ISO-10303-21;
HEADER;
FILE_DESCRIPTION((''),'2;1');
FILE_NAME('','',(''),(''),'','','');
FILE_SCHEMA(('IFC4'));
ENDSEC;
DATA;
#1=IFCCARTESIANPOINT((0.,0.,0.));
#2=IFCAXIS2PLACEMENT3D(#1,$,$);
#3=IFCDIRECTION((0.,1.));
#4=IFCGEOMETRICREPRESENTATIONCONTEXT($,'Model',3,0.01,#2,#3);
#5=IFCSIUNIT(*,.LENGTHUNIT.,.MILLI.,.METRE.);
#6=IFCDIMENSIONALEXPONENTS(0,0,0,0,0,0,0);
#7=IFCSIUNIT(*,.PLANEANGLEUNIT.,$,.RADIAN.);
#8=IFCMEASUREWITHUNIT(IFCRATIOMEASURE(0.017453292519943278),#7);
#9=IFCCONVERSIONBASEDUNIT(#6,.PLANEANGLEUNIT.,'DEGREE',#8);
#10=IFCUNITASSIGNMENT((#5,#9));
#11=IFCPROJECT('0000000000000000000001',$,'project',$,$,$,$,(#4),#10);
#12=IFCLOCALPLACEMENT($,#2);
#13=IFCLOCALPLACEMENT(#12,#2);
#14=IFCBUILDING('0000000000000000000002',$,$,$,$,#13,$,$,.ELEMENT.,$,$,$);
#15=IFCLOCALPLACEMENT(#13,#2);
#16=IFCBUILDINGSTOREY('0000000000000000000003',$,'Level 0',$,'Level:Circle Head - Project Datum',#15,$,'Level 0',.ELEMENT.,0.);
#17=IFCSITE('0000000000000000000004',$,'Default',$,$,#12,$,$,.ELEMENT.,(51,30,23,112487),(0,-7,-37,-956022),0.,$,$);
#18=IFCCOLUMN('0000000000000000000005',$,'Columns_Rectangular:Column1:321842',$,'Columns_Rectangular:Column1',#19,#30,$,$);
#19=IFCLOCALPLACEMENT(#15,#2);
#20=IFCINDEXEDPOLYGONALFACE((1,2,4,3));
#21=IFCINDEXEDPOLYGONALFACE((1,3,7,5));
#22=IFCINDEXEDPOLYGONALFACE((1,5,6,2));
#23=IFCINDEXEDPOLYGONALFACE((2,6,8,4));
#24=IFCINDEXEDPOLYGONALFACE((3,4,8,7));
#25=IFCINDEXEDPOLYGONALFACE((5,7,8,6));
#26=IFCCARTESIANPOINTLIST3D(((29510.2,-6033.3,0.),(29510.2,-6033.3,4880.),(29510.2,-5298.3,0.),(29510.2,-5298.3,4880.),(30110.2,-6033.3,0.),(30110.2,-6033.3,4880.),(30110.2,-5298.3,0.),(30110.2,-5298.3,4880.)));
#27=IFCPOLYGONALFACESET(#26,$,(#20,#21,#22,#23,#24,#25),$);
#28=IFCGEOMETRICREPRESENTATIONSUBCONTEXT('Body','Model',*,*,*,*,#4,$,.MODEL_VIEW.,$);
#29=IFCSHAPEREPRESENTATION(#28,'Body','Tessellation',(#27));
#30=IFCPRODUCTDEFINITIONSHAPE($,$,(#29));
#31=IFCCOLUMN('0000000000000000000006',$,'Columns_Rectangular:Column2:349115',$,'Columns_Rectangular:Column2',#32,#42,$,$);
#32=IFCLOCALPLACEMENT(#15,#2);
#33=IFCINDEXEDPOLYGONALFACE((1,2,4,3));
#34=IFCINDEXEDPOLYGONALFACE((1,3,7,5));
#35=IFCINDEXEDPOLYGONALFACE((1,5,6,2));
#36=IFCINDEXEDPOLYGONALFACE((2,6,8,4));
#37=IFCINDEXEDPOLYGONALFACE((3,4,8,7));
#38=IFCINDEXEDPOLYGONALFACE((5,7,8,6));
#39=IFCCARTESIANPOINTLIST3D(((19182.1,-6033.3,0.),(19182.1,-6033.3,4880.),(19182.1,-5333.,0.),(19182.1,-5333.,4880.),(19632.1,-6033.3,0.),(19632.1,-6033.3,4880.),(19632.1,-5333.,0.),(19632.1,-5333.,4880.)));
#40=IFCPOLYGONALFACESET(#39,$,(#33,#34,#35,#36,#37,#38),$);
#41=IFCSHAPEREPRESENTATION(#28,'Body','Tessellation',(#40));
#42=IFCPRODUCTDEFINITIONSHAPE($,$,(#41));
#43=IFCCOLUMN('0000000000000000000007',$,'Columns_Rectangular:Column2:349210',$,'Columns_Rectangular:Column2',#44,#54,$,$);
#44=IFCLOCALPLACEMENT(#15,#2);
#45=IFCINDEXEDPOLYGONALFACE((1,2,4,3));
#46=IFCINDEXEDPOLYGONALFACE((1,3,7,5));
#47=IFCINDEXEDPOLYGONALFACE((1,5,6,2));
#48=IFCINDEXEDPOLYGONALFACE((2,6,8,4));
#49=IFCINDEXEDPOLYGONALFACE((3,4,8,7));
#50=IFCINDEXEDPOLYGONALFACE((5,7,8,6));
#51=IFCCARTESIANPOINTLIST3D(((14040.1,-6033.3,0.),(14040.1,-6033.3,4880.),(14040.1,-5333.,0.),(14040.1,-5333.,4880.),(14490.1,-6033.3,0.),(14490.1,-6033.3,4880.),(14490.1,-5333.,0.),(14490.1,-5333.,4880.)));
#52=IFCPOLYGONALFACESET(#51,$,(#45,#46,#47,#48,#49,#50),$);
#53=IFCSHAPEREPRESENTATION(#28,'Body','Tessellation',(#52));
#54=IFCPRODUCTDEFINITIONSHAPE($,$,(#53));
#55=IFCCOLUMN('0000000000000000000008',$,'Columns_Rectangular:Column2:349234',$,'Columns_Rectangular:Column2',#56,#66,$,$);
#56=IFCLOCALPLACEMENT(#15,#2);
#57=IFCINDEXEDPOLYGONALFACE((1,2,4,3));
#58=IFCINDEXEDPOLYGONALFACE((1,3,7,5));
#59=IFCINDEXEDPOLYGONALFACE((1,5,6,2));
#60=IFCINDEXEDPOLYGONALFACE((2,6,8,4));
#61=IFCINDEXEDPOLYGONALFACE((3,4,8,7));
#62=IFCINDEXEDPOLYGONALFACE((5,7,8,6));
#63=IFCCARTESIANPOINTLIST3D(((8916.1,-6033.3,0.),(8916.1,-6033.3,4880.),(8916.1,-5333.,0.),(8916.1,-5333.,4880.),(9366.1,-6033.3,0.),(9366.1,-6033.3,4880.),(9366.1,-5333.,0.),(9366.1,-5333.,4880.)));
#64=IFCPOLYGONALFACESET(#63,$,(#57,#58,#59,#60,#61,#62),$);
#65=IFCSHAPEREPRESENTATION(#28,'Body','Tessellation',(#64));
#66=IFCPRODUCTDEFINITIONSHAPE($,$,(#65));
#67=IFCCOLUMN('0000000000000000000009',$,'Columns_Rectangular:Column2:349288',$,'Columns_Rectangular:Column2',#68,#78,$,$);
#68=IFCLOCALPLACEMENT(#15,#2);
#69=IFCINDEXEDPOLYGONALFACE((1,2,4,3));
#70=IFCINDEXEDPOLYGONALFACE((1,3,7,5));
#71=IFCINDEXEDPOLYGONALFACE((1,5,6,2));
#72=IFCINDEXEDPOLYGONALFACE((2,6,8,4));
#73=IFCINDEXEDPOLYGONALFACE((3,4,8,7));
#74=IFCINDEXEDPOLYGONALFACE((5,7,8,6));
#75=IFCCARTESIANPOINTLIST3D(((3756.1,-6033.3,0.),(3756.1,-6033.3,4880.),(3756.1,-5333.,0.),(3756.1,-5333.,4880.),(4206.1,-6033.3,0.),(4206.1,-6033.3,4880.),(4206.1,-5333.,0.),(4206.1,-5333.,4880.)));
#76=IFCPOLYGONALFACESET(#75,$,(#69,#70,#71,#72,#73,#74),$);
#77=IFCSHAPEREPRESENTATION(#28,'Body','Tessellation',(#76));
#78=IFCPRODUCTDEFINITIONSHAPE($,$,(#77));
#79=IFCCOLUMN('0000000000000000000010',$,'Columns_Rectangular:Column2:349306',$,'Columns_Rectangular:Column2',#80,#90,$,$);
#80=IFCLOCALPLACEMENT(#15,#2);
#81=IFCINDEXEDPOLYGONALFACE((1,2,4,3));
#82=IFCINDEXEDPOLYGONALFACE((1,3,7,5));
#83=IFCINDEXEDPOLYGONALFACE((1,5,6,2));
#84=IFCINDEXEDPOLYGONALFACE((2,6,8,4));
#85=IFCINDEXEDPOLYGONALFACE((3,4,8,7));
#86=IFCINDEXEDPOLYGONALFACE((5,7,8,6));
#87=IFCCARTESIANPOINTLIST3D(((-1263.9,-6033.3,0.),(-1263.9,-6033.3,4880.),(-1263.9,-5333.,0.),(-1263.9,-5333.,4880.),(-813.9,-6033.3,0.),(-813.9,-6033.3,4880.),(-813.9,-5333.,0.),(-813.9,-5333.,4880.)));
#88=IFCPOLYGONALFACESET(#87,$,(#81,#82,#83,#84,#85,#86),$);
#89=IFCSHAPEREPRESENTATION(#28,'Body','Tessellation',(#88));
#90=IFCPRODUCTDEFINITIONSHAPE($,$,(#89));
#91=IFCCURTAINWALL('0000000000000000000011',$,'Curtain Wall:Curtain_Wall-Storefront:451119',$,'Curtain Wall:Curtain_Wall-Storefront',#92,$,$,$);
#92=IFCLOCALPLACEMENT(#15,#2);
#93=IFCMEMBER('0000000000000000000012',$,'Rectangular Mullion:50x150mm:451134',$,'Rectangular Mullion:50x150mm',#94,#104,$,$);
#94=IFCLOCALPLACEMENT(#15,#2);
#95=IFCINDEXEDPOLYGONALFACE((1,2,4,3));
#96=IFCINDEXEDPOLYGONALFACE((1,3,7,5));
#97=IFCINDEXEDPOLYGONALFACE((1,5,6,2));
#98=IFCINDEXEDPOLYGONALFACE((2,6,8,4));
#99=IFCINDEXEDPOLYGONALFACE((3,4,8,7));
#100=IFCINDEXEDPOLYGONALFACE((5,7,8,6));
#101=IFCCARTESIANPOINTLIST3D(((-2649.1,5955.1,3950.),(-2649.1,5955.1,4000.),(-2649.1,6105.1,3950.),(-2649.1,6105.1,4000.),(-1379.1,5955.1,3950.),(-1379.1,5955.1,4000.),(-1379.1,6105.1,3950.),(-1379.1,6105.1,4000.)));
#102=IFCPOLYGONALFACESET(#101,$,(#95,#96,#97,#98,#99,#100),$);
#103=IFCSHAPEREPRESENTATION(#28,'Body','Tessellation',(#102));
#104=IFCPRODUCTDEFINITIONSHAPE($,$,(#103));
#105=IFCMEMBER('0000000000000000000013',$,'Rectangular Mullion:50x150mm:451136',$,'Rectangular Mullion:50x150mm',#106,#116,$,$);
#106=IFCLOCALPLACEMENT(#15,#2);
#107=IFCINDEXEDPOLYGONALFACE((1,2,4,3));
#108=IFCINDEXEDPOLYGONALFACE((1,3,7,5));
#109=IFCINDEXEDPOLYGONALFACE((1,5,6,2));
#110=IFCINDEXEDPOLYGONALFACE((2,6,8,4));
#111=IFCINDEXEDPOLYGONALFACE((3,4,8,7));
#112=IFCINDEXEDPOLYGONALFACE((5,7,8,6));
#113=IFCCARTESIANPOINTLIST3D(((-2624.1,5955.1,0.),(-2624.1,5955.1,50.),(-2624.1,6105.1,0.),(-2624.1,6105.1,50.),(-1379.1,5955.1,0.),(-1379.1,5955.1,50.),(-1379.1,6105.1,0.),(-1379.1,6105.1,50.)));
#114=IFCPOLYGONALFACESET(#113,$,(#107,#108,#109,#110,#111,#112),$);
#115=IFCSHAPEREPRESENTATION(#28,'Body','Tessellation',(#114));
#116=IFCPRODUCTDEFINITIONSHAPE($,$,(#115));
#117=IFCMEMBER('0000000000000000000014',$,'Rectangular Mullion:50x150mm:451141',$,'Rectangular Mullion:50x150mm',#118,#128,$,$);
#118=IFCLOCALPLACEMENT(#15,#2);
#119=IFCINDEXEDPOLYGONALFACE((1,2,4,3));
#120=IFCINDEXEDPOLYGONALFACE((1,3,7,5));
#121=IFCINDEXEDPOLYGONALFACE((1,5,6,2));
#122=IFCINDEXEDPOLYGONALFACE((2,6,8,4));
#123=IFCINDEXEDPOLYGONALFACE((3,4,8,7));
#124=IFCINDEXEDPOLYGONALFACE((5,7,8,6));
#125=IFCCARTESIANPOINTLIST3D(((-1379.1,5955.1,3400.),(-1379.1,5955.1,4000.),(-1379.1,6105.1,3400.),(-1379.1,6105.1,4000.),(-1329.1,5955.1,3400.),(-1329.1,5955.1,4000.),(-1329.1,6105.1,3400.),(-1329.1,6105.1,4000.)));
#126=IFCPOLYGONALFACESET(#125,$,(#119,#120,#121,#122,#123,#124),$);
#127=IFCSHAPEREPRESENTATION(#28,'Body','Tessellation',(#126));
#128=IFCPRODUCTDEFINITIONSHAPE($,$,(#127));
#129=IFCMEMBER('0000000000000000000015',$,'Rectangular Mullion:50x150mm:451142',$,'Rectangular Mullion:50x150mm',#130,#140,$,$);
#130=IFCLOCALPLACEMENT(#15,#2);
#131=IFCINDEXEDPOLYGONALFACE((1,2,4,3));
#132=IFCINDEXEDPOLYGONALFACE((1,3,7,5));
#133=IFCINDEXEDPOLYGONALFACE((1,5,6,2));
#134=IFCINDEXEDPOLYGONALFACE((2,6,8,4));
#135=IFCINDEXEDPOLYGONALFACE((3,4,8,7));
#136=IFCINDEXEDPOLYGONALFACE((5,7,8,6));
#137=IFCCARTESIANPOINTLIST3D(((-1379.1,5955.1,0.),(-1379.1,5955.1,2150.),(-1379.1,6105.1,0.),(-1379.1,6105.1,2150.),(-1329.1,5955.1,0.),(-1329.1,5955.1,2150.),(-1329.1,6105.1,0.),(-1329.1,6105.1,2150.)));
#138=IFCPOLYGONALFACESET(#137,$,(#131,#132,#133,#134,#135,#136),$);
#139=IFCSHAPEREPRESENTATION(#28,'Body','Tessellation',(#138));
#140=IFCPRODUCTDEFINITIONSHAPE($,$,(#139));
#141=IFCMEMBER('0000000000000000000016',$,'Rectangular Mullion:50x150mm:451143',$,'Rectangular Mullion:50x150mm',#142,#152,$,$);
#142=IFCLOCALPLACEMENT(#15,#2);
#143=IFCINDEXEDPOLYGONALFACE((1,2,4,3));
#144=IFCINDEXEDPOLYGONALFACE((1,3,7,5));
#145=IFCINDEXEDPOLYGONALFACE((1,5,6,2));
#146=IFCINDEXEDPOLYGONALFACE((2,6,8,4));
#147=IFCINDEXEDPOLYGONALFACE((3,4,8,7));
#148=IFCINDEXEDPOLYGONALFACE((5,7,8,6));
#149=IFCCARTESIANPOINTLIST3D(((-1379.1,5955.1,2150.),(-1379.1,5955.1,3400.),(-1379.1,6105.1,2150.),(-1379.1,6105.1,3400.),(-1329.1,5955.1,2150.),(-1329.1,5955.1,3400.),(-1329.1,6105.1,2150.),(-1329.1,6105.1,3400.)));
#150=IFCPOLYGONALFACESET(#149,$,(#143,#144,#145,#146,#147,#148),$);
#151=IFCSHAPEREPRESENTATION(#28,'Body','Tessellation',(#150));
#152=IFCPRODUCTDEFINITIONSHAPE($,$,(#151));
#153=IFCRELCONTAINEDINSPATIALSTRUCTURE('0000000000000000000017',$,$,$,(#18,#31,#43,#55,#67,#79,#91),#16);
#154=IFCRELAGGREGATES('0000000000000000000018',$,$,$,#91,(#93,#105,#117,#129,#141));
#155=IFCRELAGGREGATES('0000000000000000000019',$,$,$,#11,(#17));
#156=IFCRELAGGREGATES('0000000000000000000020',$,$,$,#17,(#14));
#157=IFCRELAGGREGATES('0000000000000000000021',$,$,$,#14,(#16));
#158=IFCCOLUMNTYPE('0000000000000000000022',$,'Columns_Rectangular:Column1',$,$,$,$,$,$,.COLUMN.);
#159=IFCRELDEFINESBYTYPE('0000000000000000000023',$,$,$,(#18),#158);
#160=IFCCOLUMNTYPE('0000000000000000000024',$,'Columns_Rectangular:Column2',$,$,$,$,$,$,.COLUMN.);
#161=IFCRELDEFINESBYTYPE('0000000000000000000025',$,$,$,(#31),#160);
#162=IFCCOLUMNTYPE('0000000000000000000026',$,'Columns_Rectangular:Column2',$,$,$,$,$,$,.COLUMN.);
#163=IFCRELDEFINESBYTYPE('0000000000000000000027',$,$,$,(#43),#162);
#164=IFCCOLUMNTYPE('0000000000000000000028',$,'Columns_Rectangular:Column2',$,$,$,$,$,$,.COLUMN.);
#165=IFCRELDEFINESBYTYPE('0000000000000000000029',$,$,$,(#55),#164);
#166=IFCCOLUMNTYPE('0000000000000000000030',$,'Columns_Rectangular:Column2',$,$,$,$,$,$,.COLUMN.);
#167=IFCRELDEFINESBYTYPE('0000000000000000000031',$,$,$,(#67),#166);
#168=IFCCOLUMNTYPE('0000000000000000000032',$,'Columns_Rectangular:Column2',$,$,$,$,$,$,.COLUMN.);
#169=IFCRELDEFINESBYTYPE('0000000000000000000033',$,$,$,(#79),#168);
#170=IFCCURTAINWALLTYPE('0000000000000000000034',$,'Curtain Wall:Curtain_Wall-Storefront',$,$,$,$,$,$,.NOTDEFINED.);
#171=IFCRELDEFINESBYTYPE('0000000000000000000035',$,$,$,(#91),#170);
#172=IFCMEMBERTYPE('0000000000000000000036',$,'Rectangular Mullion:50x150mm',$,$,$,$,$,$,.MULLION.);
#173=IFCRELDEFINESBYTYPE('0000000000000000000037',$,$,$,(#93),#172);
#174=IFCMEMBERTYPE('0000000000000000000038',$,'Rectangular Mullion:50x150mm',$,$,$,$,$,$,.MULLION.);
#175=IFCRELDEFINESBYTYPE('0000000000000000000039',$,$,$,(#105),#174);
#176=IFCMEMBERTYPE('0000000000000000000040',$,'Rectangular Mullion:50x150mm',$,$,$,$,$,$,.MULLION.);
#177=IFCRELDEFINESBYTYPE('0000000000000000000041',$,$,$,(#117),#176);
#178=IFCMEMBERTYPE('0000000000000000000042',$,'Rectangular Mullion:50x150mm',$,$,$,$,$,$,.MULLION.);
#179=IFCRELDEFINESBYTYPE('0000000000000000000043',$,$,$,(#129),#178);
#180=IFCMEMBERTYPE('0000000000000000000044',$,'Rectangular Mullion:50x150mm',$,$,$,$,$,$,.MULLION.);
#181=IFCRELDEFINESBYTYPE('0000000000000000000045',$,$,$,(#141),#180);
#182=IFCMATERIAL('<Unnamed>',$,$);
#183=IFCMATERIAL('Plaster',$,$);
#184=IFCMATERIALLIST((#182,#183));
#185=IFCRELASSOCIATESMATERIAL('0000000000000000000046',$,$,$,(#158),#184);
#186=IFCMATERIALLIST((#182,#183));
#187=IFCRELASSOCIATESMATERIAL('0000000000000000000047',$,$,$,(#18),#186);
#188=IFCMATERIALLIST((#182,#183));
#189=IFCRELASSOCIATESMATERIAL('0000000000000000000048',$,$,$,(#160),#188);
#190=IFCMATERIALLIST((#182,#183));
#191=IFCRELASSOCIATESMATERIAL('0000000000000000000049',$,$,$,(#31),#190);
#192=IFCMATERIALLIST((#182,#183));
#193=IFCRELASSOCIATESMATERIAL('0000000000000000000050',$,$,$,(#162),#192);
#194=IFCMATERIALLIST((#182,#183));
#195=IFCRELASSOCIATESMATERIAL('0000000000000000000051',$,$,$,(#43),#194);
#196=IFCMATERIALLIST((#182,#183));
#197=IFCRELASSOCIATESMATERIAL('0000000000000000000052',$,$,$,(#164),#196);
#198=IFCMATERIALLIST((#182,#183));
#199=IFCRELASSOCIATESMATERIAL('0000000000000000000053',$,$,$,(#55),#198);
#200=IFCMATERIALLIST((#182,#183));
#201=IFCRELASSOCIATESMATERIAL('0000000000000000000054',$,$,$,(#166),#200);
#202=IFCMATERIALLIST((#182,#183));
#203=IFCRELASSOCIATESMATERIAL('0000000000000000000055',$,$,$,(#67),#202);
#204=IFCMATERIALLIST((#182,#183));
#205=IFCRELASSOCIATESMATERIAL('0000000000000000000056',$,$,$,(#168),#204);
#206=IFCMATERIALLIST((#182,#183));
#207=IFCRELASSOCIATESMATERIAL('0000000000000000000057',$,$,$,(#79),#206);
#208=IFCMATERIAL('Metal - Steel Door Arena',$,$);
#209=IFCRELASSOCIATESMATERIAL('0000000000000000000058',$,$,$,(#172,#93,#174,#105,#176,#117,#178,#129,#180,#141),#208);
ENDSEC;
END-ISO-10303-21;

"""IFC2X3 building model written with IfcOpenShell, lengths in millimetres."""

from ifc_helpers import new_model, entity, si_unit, converted_unit, direction, frame, frame_2d, origin, origin_2d_with_axis, place, context, subcontext, project, spatial, rectangle, extrude, source, transform, mapped, material, material_list, type_object, type_shapes, element, aggregate, save


model = new_model("IFC2X3")

# Units and contexts
model_context = context("Model", 3, precision=0.01, world=origin(), true_north=direction((0.0, 1.0)))
body_context = subcontext(model_context, "Body", "Model", "MODEL_VIEW")
ifc_project = project(units=[si_unit("LENGTHUNIT", "METRE", prefix="MILLI"), converted_unit("PLANEANGLEUNIT", "DEGREE", entity("IfcRatioMeasure", 0.017453292519943278), si_unit("PLANEANGLEUNIT", "RADIAN"), dimensions=[0, 0, 0, 0, 0, 0, 0])], contexts=[model_context])

# Site, building, storey
site_placement = place(None, origin())
site = spatial("IfcSite", under=ifc_project, at=site_placement, Name="Default", CompositionType="ELEMENT", RefLatitude=(51, 30, 23, 112487), RefLongitude=(0, -7, -37, -956022), RefElevation=0.0)
building_placement = place(site_placement, origin())
building = spatial("IfcBuilding", under=site, at=building_placement, CompositionType="ELEMENT")
storey_placement = place(building_placement, origin())
storey = spatial("IfcBuildingStorey", under=building, at=storey_placement, Name="Level 0", ObjectType="Level:Circle Head - Project Datum", LongName="Level 0", CompositionType="ELEMENT", Elevation=0.0)

# Columns
ifc_material_1 = material(Name="<Unnamed>")
ifc_material_2 = material(Name="Plaster")
ifc_material_list_1 = material_list([ifc_material_1, ifc_material_2])
ifc_material_list_2 = material_list([ifc_material_1, ifc_material_2])
column_type_1 = type_object("IfcColumnType", Name="Columns_Rectangular:Column1", PredefinedType="COLUMN", material=ifc_material_list_2)
shared_shape_1 = source(origin(), body_context, "Body", "SweptSolid", [
    extrude(rectangle(XDim=735.0, YDim=600.0, at=frame_2d((0.0, 0.0), x_axis=(1.0, 0.0))), frame((29810.2, -5665.8, 0.0), z_axis=(0.0, 0.0, 1.0), x_axis=(0.0, -1.0, 0.0)), (0.0, 0.0, 1.0), 4880.0),
])
type_shapes(column_type_1, [shared_shape_1])
column_1_placement = place(storey_placement, origin())
element("IfcColumn", 1, at=column_1_placement, inside=storey, type_object=column_type_1, material=ifc_material_list_1, Name="Columns_Rectangular:Column1:321842", ObjectType="Columns_Rectangular:Column1", context=body_context, shape_type="MappedRepresentation", body=[
    mapped(shared_shape_1, transform((0.0, 0.0, 0.0), scale=1.0)),
])
ifc_material_list_3 = material_list([ifc_material_1, ifc_material_2])
ifc_material_list_4 = material_list([ifc_material_1, ifc_material_2])
column_type_2 = type_object("IfcColumnType", Name="Columns_Rectangular:Column2", PredefinedType="COLUMN", material=ifc_material_list_4)
shared_shape_2 = source(origin(), body_context, "Body", "SweptSolid", [
    extrude(rectangle(XDim=700.3, YDim=450.0, at=frame_2d((0.0, 0.0), x_axis=(1.0, 0.0))), frame((19407.1, -5683.1, 0.0), z_axis=(0.0, 0.0, 1.0), x_axis=(0.0, -1.0, 0.0)), (0.0, 0.0, 1.0), 4880.0),
])
type_shapes(column_type_2, [shared_shape_2])
column_2_placement = place(storey_placement, origin())
element("IfcColumn", 2, at=column_2_placement, inside=storey, type_object=column_type_2, material=ifc_material_list_3, Name="Columns_Rectangular:Column2:349115", ObjectType="Columns_Rectangular:Column2", context=body_context, shape_type="MappedRepresentation", body=[
    mapped(shared_shape_2, transform((0.0, 0.0, 0.0), scale=1.0)),
])
ifc_material_list_5 = material_list([ifc_material_1, ifc_material_2])
ifc_material_list_6 = material_list([ifc_material_1, ifc_material_2])
column_type_3 = type_object("IfcColumnType", Name="Columns_Rectangular:Column2", PredefinedType="COLUMN", material=ifc_material_list_6)
shared_shape_3 = source(origin(), body_context, "Body", "SweptSolid", [
    extrude(rectangle(XDim=700.3, YDim=450.0, at=frame_2d((0.0, 0.0), x_axis=(1.0, 0.0))), frame((14265.1, -5683.1, 0.0), z_axis=(0.0, 0.0, 1.0), x_axis=(0.0, -1.0, 0.0)), (0.0, 0.0, 1.0), 4880.0),
])
type_shapes(column_type_3, [shared_shape_3])
column_3_placement = place(storey_placement, origin())
element("IfcColumn", 3, at=column_3_placement, inside=storey, type_object=column_type_3, material=ifc_material_list_5, Name="Columns_Rectangular:Column2:349210", ObjectType="Columns_Rectangular:Column2", context=body_context, shape_type="MappedRepresentation", body=[
    mapped(shared_shape_3, transform((0.0, 0.0, 0.0), scale=1.0)),
])
ifc_material_list_7 = material_list([ifc_material_1, ifc_material_2])
ifc_material_list_8 = material_list([ifc_material_1, ifc_material_2])
column_type_4 = type_object("IfcColumnType", Name="Columns_Rectangular:Column2", PredefinedType="COLUMN", material=ifc_material_list_8)
shared_shape_4 = source(origin(), body_context, "Body", "SweptSolid", [
    extrude(rectangle(XDim=700.3, YDim=450.0, at=frame_2d((0.0, 0.0), x_axis=(1.0, 0.0))), frame((9141.1, -5683.1, 0.0), z_axis=(0.0, 0.0, 1.0), x_axis=(0.0, -1.0, 0.0)), (0.0, 0.0, 1.0), 4880.0),
])
type_shapes(column_type_4, [shared_shape_4])
column_4_placement = place(storey_placement, origin())
element("IfcColumn", 4, at=column_4_placement, inside=storey, type_object=column_type_4, material=ifc_material_list_7, Name="Columns_Rectangular:Column2:349234", ObjectType="Columns_Rectangular:Column2", context=body_context, shape_type="MappedRepresentation", body=[
    mapped(shared_shape_4, transform((0.0, 0.0, 0.0), scale=1.0)),
])
ifc_material_list_9 = material_list([ifc_material_1, ifc_material_2])
ifc_material_list_10 = material_list([ifc_material_1, ifc_material_2])
column_type_5 = type_object("IfcColumnType", Name="Columns_Rectangular:Column2", PredefinedType="COLUMN", material=ifc_material_list_10)
shared_shape_5 = source(origin(), body_context, "Body", "SweptSolid", [
    extrude(rectangle(XDim=700.3, YDim=450.0, at=frame_2d((0.0, 0.0), x_axis=(1.0, 0.0))), frame((3981.1, -5683.1, 0.0), z_axis=(0.0, 0.0, 1.0), x_axis=(0.0, -1.0, 0.0)), (0.0, 0.0, 1.0), 4880.0),
])
type_shapes(column_type_5, [shared_shape_5])
column_5_placement = place(storey_placement, origin())
element("IfcColumn", 5, at=column_5_placement, inside=storey, type_object=column_type_5, material=ifc_material_list_9, Name="Columns_Rectangular:Column2:349288", ObjectType="Columns_Rectangular:Column2", context=body_context, shape_type="MappedRepresentation", body=[
    mapped(shared_shape_5, transform((0.0, 0.0, 0.0), scale=1.0)),
])
ifc_material_list_11 = material_list([ifc_material_1, ifc_material_2])
ifc_material_list_12 = material_list([ifc_material_1, ifc_material_2])
column_type_6 = type_object("IfcColumnType", Name="Columns_Rectangular:Column2", PredefinedType="COLUMN", material=ifc_material_list_12)
shared_shape_6 = source(origin(), body_context, "Body", "SweptSolid", [
    extrude(rectangle(XDim=700.3, YDim=450.0, at=frame_2d((0.0, 0.0), x_axis=(1.0, 0.0))), frame((-1038.9, -5683.1, 0.0), z_axis=(0.0, 0.0, 1.0), x_axis=(0.0, -1.0, 0.0)), (0.0, 0.0, 1.0), 4880.0),
])
type_shapes(column_type_6, [shared_shape_6])
column_6_placement = place(storey_placement, origin())
element("IfcColumn", 6, at=column_6_placement, inside=storey, type_object=column_type_6, material=ifc_material_list_11, Name="Columns_Rectangular:Column2:349306", ObjectType="Columns_Rectangular:Column2", context=body_context, shape_type="MappedRepresentation", body=[
    mapped(shared_shape_6, transform((0.0, 0.0, 0.0), scale=1.0)),
])

# Curtain wall, members
curtain_wall_type = type_object("IfcCurtainWallType", Name="Curtain Wall:Curtain_Wall-Storefront", PredefinedType="NOTDEFINED")
curtain_wall_placement = place(storey_placement, origin())
curtain_wall = element("IfcCurtainWall", 7, at=curtain_wall_placement, inside=storey, type_object=curtain_wall_type, Name="Curtain Wall:Curtain_Wall-Storefront:451119", ObjectType="Curtain Wall:Curtain_Wall-Storefront")
ifc_material_3 = material(Name="Metal - Steel Door Arena")
member_type_1 = type_object("IfcMemberType", Name="Rectangular Mullion:50x150mm", PredefinedType="MULLION", material=ifc_material_3)
shared_shape_7 = source(origin(), body_context, "Body", "SweptSolid", [
    extrude(rectangle(XDim=150.0, YDim=50.0, at=origin_2d_with_axis()), frame((-25.0, 0.0, -1270.0), z_axis=(0.0, 0.0, 1.0), x_axis=(0.0, -1.0, 0.0)), (0.0, 0.0, 1.0), 1270.0),
])
type_shapes(member_type_1, [shared_shape_7])
member_1_placement = place(curtain_wall_placement, frame((-2649.1, 6030.1, 4000.0), z_axis=(-1.0, 0.0, 0.0), x_axis=(0.0, 0.0, 1.0)))
member_1 = element("IfcMember", 8, at=member_1_placement, type_object=member_type_1, material=ifc_material_3, Name="Rectangular Mullion:50x150mm:451134", ObjectType="Rectangular Mullion:50x150mm", context=body_context, shape_type="MappedRepresentation", body=[
    mapped(shared_shape_7, transform((0.0, 0.0, 0.0), scale=1.0)),
])
member_type_2 = type_object("IfcMemberType", Name="Rectangular Mullion:50x150mm", PredefinedType="MULLION", material=ifc_material_3)
shared_shape_8 = source(origin(), body_context, "Body", "SweptSolid", [
    extrude(rectangle(XDim=150.0, YDim=50.0, at=origin_2d_with_axis()), frame((-25.0, 0.0, -1245.0), z_axis=(0.0, 0.0, 1.0), x_axis=(0.0, -1.0, 0.0)), (0.0, 0.0, 1.0), 1245.0),
])
type_shapes(member_type_2, [shared_shape_8])
member_2_placement = place(curtain_wall_placement, frame((-1379.1, 6030.1, 0.0), z_axis=(1.0, 0.0, 0.0), x_axis=(0.0, 0.0, -1.0)))
member_2 = element("IfcMember", 9, at=member_2_placement, type_object=member_type_2, material=ifc_material_3, Name="Rectangular Mullion:50x150mm:451136", ObjectType="Rectangular Mullion:50x150mm", context=body_context, shape_type="MappedRepresentation", body=[
    mapped(shared_shape_8, transform((0.0, 0.0, 0.0), scale=1.0)),
])
member_type_3 = type_object("IfcMemberType", Name="Rectangular Mullion:50x150mm", PredefinedType="MULLION", material=ifc_material_3)
shared_shape_9 = source(origin(), body_context, "Body", "SweptSolid", [
    extrude(rectangle(XDim=150.0, YDim=50.0, at=origin_2d_with_axis()), frame((-25.0, 0.0, -600.0), z_axis=(0.0, 0.0, 1.0), x_axis=(0.0, -1.0, 0.0)), (0.0, 0.0, 1.0), 600.0),
])
type_shapes(member_type_3, [shared_shape_9])
member_3_placement = place(curtain_wall_placement, frame((-1329.1, 6030.1, 4000.0)))
member_3 = element("IfcMember", 10, at=member_3_placement, type_object=member_type_3, material=ifc_material_3, Name="Rectangular Mullion:50x150mm:451141", ObjectType="Rectangular Mullion:50x150mm", context=body_context, shape_type="MappedRepresentation", body=[
    mapped(shared_shape_9, transform((0.0, 0.0, 0.0), scale=1.0)),
])
member_type_4 = type_object("IfcMemberType", Name="Rectangular Mullion:50x150mm", PredefinedType="MULLION", material=ifc_material_3)
shared_shape_10 = source(origin(), body_context, "Body", "SweptSolid", [
    extrude(rectangle(XDim=150.0, YDim=50.0, at=origin_2d_with_axis()), frame((-25.0, 0.0, -2150.0), z_axis=(0.0, 0.0, 1.0), x_axis=(0.0, -1.0, 0.0)), (0.0, 0.0, 1.0), 2150.0),
])
type_shapes(member_type_4, [shared_shape_10])
member_4_placement = place(curtain_wall_placement, frame((-1329.1, 6030.1, 2150.0)))
member_4 = element("IfcMember", 11, at=member_4_placement, type_object=member_type_4, material=ifc_material_3, Name="Rectangular Mullion:50x150mm:451142", ObjectType="Rectangular Mullion:50x150mm", context=body_context, shape_type="MappedRepresentation", body=[
    mapped(shared_shape_10, transform((0.0, 0.0, 0.0), scale=1.0)),
])
member_type_5 = type_object("IfcMemberType", Name="Rectangular Mullion:50x150mm", PredefinedType="MULLION", material=ifc_material_3)
shared_shape_11 = source(origin(), body_context, "Body", "SweptSolid", [
    extrude(rectangle(XDim=150.0, YDim=50.0, at=origin_2d_with_axis()), frame((-25.0, 0.0, -1250.0), z_axis=(0.0, 0.0, 1.0), x_axis=(0.0, -1.0, 0.0)), (0.0, 0.0, 1.0), 1250.0),
])
type_shapes(member_type_5, [shared_shape_11])
member_5_placement = place(curtain_wall_placement, frame((-1329.1, 6030.1, 3400.0)))
member_5 = element("IfcMember", 12, at=member_5_placement, type_object=member_type_5, material=ifc_material_3, Name="Rectangular Mullion:50x150mm:451143", ObjectType="Rectangular Mullion:50x150mm", context=body_context, shape_type="MappedRepresentation", body=[
    mapped(shared_shape_11, transform((0.0, 0.0, 0.0), scale=1.0)),
])

aggregate(curtain_wall, [member_1, member_2, member_3, member_4, member_5])

save(model, "model.ifc")
